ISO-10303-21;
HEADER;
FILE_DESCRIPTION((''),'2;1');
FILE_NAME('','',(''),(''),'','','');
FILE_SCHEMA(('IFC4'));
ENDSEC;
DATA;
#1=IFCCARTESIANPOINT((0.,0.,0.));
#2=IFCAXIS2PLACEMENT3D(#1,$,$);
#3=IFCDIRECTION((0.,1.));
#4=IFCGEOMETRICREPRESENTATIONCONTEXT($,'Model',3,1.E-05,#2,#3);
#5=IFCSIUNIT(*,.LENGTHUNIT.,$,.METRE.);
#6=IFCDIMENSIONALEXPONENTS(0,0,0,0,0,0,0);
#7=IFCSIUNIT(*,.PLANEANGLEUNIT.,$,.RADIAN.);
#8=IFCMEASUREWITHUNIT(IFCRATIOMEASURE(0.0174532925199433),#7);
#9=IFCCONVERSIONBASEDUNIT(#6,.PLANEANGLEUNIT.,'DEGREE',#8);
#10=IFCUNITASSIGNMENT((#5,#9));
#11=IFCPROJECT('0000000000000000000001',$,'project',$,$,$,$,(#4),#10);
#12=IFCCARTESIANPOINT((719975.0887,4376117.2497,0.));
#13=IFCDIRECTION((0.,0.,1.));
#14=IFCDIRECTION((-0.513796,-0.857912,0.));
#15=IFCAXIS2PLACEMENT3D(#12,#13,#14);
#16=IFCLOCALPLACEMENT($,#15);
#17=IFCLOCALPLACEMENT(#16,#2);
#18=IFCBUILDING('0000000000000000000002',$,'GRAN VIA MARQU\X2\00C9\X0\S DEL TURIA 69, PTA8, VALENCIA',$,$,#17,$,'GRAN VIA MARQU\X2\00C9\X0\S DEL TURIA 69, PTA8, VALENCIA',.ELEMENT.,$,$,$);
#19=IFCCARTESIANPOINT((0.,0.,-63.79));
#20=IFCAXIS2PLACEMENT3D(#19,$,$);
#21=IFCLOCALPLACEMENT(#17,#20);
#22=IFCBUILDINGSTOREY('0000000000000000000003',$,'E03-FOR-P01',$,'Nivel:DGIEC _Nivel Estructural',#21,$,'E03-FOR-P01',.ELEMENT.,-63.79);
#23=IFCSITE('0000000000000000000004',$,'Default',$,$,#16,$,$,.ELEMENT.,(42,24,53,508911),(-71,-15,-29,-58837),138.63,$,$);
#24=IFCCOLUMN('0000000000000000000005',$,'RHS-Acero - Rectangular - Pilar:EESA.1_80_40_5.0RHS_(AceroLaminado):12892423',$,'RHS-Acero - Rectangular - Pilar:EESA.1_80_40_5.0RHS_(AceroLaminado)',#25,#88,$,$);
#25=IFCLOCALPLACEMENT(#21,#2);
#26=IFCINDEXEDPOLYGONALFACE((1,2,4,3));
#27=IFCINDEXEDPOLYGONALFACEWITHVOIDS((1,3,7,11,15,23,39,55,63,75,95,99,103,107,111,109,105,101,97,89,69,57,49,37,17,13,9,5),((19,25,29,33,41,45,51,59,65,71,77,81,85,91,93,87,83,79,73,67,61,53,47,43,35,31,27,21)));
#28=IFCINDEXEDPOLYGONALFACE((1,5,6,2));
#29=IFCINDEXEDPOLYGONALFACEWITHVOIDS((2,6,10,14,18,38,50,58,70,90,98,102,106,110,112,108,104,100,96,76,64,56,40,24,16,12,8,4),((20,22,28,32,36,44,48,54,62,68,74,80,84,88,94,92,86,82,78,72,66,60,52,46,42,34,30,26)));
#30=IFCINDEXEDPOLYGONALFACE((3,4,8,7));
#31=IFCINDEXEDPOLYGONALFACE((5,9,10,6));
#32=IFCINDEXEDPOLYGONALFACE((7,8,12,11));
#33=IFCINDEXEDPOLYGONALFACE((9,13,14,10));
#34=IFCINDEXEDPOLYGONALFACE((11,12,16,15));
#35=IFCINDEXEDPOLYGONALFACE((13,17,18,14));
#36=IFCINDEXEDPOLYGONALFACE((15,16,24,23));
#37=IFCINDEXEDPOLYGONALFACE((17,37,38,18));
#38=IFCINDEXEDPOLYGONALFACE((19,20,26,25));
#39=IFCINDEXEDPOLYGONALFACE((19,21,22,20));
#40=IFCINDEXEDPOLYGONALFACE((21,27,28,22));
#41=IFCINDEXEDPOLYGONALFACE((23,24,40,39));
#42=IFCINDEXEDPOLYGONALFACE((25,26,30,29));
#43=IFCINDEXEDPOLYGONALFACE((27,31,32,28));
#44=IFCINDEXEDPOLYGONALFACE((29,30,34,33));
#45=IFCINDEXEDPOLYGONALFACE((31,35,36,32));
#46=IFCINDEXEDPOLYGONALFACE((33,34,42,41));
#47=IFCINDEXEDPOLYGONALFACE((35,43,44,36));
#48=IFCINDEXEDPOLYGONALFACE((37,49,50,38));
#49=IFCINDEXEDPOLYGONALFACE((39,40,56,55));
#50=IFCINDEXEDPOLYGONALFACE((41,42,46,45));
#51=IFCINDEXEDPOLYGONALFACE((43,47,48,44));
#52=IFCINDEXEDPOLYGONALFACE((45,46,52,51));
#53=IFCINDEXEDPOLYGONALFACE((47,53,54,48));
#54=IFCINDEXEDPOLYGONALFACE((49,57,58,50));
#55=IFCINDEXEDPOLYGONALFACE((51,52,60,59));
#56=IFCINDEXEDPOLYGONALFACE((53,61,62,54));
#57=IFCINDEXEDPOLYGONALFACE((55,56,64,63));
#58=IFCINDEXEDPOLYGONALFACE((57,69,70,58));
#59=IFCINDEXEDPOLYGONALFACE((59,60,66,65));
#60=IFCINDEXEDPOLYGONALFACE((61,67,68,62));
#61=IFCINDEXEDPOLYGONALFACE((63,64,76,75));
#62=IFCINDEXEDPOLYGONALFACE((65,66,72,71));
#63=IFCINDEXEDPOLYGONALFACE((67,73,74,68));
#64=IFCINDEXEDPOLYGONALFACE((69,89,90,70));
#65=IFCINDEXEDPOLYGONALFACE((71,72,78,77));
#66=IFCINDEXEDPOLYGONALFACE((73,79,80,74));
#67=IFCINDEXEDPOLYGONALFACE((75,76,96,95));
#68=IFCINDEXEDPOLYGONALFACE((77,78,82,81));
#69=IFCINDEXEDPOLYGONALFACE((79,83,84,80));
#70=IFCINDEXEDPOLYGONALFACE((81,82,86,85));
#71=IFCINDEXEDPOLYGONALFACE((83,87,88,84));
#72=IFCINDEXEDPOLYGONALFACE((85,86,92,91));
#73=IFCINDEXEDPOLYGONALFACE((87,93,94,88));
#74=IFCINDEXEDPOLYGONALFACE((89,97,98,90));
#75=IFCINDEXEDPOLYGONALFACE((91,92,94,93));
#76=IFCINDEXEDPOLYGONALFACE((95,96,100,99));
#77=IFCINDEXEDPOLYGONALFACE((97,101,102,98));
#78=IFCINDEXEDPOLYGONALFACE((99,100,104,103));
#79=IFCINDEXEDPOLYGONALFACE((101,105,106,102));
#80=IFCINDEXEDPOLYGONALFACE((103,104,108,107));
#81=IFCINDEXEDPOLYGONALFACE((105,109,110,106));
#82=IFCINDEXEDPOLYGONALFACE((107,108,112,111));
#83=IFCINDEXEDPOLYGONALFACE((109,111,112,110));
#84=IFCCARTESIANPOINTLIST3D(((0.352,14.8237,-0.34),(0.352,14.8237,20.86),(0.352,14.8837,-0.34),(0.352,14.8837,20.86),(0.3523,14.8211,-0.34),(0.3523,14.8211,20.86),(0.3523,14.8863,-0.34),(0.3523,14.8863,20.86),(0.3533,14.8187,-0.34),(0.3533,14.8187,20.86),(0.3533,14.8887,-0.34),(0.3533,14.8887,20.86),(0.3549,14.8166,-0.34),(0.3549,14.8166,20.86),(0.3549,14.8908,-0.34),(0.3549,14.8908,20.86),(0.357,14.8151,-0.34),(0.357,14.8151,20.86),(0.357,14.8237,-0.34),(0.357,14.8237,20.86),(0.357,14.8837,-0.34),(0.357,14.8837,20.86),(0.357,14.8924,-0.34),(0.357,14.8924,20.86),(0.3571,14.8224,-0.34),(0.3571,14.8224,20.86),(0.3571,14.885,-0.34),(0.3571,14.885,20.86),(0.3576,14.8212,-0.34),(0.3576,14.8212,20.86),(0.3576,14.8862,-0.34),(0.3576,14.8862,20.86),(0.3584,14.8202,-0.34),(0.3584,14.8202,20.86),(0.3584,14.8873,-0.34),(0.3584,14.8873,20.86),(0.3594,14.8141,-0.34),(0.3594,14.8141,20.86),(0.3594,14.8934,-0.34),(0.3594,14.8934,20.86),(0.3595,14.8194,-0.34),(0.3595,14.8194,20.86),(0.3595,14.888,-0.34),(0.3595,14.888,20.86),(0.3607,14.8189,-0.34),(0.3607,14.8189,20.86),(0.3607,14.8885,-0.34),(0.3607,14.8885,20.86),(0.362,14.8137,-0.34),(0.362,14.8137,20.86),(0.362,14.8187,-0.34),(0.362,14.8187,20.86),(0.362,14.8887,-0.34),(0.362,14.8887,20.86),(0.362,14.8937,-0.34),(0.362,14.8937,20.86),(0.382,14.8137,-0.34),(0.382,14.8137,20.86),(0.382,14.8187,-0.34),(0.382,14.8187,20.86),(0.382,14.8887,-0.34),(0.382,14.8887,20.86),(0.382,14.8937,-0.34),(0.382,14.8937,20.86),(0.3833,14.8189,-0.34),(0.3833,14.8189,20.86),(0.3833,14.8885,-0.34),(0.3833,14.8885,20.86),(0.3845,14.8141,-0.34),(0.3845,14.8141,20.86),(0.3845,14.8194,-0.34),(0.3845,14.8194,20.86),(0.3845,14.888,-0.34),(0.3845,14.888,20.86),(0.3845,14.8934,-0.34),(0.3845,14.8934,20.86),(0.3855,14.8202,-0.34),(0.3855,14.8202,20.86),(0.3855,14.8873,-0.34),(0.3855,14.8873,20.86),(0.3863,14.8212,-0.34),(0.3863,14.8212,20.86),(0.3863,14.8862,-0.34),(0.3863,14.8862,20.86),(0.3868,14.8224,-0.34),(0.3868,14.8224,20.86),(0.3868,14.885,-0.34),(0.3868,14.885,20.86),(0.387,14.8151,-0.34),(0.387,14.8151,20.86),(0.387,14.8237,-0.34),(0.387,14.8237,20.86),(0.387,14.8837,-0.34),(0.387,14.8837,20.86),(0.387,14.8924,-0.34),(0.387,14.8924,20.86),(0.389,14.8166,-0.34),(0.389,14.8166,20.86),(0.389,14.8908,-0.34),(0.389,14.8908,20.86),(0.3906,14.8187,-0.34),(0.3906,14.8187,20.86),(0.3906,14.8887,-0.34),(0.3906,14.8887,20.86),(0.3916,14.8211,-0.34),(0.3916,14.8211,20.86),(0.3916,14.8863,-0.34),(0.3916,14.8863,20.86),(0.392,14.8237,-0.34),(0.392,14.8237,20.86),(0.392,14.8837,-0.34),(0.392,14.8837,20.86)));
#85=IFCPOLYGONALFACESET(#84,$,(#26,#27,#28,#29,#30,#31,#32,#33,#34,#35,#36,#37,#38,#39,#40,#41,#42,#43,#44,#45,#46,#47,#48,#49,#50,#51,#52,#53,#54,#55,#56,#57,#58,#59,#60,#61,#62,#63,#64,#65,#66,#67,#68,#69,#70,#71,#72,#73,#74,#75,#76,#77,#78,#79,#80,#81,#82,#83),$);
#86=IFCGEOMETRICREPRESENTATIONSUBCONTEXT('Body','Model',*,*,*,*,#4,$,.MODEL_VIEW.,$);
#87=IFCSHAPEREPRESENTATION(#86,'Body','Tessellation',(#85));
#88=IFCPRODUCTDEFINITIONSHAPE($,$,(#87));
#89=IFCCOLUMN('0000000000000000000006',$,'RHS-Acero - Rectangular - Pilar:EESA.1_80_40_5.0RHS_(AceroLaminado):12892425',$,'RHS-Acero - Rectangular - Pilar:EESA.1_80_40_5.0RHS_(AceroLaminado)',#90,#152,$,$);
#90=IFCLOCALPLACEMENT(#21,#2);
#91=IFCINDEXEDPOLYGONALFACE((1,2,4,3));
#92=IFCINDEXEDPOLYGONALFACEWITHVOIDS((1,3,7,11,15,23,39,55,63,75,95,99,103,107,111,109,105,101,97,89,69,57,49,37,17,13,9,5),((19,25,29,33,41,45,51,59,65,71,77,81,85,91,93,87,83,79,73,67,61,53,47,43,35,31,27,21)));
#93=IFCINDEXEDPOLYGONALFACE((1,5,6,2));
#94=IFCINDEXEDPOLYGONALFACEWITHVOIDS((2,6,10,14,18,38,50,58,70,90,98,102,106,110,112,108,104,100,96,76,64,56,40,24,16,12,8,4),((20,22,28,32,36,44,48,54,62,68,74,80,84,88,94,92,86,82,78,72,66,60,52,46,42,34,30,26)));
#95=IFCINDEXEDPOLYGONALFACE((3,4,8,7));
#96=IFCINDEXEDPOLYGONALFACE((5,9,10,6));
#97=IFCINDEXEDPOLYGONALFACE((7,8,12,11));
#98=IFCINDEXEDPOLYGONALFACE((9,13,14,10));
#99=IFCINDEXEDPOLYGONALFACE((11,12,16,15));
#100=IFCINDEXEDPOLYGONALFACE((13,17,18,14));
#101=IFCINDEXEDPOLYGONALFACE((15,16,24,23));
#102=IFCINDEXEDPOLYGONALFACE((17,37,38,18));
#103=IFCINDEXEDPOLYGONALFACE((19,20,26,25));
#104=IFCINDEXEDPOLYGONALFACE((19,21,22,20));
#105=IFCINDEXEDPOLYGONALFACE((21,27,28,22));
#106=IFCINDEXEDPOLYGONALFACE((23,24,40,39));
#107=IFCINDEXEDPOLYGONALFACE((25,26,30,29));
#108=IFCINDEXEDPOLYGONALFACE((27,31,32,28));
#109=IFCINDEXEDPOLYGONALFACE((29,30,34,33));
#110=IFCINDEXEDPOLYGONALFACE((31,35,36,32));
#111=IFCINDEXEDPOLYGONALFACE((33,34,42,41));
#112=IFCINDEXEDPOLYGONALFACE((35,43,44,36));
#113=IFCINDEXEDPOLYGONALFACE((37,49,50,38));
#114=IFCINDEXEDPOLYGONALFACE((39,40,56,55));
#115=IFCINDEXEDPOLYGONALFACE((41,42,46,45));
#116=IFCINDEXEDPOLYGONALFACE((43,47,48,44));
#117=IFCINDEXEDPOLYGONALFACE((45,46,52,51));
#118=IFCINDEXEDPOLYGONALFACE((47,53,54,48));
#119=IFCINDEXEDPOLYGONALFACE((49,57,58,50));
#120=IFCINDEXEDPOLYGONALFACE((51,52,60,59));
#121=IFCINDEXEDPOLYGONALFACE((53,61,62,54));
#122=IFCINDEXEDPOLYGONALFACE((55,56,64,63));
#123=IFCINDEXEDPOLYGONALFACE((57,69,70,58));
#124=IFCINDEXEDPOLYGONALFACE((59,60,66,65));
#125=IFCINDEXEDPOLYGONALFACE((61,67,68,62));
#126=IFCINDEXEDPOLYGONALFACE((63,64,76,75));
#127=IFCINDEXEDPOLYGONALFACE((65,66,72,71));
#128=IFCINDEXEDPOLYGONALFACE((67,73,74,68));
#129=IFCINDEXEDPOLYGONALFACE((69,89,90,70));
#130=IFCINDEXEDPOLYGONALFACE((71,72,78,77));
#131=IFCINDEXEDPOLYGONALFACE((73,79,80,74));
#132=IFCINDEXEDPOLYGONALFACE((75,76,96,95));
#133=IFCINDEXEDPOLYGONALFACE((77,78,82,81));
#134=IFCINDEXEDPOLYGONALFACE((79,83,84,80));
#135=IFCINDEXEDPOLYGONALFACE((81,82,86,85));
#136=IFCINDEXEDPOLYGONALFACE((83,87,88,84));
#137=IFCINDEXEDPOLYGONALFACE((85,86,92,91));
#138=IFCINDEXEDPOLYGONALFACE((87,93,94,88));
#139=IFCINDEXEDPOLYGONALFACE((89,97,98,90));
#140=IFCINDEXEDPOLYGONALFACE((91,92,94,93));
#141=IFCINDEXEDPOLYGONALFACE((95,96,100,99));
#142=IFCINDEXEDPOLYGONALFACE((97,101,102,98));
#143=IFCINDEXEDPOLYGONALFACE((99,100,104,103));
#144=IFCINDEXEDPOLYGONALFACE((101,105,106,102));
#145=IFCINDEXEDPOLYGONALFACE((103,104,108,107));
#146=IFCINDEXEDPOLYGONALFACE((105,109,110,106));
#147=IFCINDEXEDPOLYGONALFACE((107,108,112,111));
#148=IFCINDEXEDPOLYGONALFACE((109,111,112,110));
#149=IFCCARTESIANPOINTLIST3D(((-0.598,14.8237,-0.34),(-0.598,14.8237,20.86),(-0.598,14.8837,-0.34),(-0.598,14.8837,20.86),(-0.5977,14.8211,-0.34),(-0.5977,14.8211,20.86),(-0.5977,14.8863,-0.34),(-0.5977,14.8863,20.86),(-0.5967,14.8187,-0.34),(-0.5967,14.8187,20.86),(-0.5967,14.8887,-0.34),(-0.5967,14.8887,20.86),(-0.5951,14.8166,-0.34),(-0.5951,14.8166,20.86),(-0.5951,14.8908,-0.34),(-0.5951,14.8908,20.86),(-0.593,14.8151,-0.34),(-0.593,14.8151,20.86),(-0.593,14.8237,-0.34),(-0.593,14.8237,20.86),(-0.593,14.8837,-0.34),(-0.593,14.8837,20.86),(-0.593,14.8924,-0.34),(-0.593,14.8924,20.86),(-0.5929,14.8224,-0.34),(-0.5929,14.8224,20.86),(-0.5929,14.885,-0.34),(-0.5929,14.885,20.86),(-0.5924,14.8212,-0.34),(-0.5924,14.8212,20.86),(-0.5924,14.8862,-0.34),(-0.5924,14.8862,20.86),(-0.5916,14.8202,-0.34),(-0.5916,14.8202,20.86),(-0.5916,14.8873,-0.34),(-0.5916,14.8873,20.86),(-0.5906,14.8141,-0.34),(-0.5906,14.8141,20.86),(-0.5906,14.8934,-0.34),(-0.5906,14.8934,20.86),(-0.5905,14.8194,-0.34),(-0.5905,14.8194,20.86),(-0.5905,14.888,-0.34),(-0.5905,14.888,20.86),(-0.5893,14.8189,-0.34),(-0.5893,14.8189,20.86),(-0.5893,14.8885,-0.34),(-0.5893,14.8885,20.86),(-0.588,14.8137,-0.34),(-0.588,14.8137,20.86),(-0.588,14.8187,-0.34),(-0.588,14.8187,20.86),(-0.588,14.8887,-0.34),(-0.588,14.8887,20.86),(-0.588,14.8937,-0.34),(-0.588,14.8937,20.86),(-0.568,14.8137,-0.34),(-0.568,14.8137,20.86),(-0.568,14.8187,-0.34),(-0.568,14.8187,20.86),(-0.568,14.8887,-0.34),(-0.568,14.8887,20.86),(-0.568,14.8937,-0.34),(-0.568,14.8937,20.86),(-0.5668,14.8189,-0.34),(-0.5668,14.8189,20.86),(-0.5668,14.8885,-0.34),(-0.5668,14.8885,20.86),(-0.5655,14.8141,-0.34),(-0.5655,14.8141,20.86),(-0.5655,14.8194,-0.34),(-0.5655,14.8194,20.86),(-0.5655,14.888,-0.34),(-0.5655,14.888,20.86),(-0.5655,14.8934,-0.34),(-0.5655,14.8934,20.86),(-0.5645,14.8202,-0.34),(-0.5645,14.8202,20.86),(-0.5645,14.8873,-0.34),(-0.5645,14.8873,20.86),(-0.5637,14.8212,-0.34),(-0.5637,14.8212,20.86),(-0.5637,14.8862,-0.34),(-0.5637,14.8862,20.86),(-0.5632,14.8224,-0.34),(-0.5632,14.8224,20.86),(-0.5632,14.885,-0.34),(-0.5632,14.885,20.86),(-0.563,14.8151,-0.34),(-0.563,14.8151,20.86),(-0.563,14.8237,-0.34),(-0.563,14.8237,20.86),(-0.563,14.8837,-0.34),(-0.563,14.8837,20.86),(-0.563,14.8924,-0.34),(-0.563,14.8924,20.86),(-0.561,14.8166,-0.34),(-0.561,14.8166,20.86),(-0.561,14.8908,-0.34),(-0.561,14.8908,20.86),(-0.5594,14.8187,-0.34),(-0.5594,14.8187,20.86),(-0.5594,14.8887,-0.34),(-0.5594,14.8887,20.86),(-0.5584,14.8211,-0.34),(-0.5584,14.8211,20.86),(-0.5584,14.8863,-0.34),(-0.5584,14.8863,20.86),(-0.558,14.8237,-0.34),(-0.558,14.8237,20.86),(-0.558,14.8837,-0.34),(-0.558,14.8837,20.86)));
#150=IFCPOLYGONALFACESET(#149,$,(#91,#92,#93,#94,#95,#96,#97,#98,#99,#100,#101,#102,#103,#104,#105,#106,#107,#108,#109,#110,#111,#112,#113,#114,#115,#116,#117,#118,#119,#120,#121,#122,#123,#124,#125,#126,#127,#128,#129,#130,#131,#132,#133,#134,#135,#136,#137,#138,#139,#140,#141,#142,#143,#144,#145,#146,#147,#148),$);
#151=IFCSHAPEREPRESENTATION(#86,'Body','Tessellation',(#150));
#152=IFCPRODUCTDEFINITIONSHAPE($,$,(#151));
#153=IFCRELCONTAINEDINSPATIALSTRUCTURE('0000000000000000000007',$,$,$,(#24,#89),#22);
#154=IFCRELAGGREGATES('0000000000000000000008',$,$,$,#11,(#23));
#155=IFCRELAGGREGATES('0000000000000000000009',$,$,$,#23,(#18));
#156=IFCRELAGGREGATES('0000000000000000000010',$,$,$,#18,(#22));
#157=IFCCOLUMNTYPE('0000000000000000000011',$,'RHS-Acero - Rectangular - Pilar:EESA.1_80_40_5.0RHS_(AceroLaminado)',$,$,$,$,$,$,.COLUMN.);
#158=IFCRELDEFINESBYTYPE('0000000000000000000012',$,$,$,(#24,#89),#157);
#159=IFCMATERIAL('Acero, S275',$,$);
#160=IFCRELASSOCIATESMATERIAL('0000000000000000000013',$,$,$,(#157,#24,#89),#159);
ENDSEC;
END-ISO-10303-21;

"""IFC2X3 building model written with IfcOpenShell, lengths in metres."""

from ifc_helpers import new_model, entity, si_unit, converted_unit, direction, frame, frame_2d, origin, place, context, subcontext, project, spatial, polyline, circle_curve, parameter, trimmed, segment, composite_curve, outline, extrude, source, transform, mapped, material, type_object, type_shapes, element, save


model = new_model("IFC2X3")

# Units and contexts
model_context = context("Model", 3, precision=1e-05, world=origin(), true_north=direction((0.0, 1.0)))
body_context = subcontext(model_context, "Body", "Model", "MODEL_VIEW")
ifc_project = project(units=[si_unit("LENGTHUNIT", "METRE"), converted_unit("PLANEANGLEUNIT", "DEGREE", entity("IfcRatioMeasure", 0.0174532925199433), si_unit("PLANEANGLEUNIT", "RADIAN"), dimensions=[0, 0, 0, 0, 0, 0, 0])], contexts=[model_context])

# Site, building, storey
site_placement = place(None, frame((719975.0887, 4376117.2497, 0.0), z_axis=(0.0, 0.0, 1.0), x_axis=(-0.513796, -0.857912, 0.0)))
site = spatial("IfcSite", under=ifc_project, at=site_placement, Name="Default", CompositionType="ELEMENT", RefLatitude=(42, 24, 53, 508911), RefLongitude=(-71, -15, -29, -58837), RefElevation=138.63)
building_placement = place(site_placement, origin())
building = spatial("IfcBuilding", under=site, at=building_placement, Name="GRAN VIA MARQUÉS DEL TURIA 69, PTA8, VALENCIA", LongName="GRAN VIA MARQUÉS DEL TURIA 69, PTA8, VALENCIA", CompositionType="ELEMENT")
storey_placement = place(building_placement, frame((0.0, 0.0, -63.79)))
storey = spatial("IfcBuildingStorey", under=building, at=storey_placement, Name="E03-FOR-P01", ObjectType="Nivel:DGIEC _Nivel Estructural", LongName="E03-FOR-P01", CompositionType="ELEMENT", Elevation=-63.79)

# Columns
ifc_material_1 = material(Name="Acero, S275")
column_type_1 = type_object("IfcColumnType", Name="RHS-Acero - Rectangular - Pilar:EESA.1_80_40_5.0RHS_(AceroLaminado)", PredefinedType="COLUMN", material=ifc_material_1)
shared_shape_1 = source(origin(), body_context, "Body", "SweptSolid", [
    extrude(outline(composite_curve([segment(polyline([(-0.01, -0.04), (0.01, -0.04)]), True, "CONTINUOUS"), segment(trimmed(circle_curve(frame_2d((0.01, -0.03), x_axis=(-1.0, 0.0)), 0.01), [parameter(90.0)], [parameter(180.0)], True, "PARAMETER"), True, "CONTINUOUS"), segment(polyline([(0.02, -0.03), (0.02, 0.03)]), True, "CONTINUOUS"), segment(trimmed(circle_curve(frame_2d((0.01, 0.03), x_axis=(-1.0, 0.0)), 0.01), [parameter(180.0)], [parameter(270.0)], True, "PARAMETER"), True, "CONTINUOUS"), segment(polyline([(0.01, 0.04), (-0.01, 0.04)]), True, "CONTINUOUS"), segment(trimmed(circle_curve(frame_2d((-0.01, 0.03), x_axis=(-1.0, 0.0)), 0.01), [parameter(270.0)], [parameter(360.0)], True, "PARAMETER"), True, "CONTINUOUS"), segment(polyline([(-0.02, 0.03), (-0.02, -0.03)]), True, "CONTINUOUS"), segment(trimmed(circle_curve(frame_2d((-0.01, -0.03), x_axis=(-1.0, 0.0)), 0.01), [parameter(360.0)], [parameter(90.0)], True, "PARAMETER"), True, "CONTINUOUS")], self_intersect=False), holes=[composite_curve([segment(trimmed(circle_curve(frame_2d((-0.01, -0.03), x_axis=(-1.0, 0.0)), 0.005), [parameter(0.0)], [parameter(90.0)], True, "PARAMETER"), False, "CONTINUOUS"), segment(polyline([(-0.015, -0.03), (-0.015, 0.03)]), True, "CONTINUOUS"), segment(trimmed(circle_curve(frame_2d((-0.01, 0.03), x_axis=(-1.0, 0.0)), 0.005), [parameter(270.0)], [parameter(0.0)], True, "PARAMETER"), False, "CONTINUOUS"), segment(polyline([(-0.01, 0.035), (0.01, 0.035)]), True, "CONTINUOUS"), segment(trimmed(circle_curve(frame_2d((0.01, 0.03), x_axis=(-1.0, 0.0)), 0.005), [parameter(180.0)], [parameter(270.0)], True, "PARAMETER"), False, "CONTINUOUS"), segment(polyline([(0.015, 0.03), (0.015, -0.03)]), True, "CONTINUOUS"), segment(trimmed(circle_curve(frame_2d((0.01, -0.03), x_axis=(-1.0, 0.0)), 0.005), [parameter(90.0)], [parameter(180.0)], True, "PARAMETER"), False, "CONTINUOUS"), segment(polyline([(0.01, -0.035), (-0.01, -0.035)]), True, "CONTINUOUS")], self_intersect=False)]), frame((0.0, 0.0, -64.13), z_axis=(0.0, 0.0, 1.0), x_axis=(-1.0, 0.0, 0.0)), (0.0, 0.0, 1.0), 21.2),
])
type_shapes(column_type_1, [shared_shape_1])
for number, where, z_axis, x_axis, name in (
    (1, (0.372, 14.8537, 63.79), (0.0, 0.0, 1.0), (-1.0, 0.0, 0.0), "RHS-Acero - Rectangular - Pilar:EESA.1_80_40_5.0RHS_(AceroLaminado):12892423"),
    (2, (-0.578, 14.8537, 63.79), (0.0, 0.0, 1.0), (-1.0, 0.0, 0.0), "RHS-Acero - Rectangular - Pilar:EESA.1_80_40_5.0RHS_(AceroLaminado):12892425"),
):
    element("IfcColumn", number, at=place(storey_placement, frame(where, z_axis=z_axis, x_axis=x_axis)), inside=storey, type_object=column_type_1, material=ifc_material_1, Name=name, ObjectType="RHS-Acero - Rectangular - Pilar:EESA.1_80_40_5.0RHS_(AceroLaminado)", context=body_context, shape_type="MappedRepresentation", body=[
        mapped(shared_shape_1, transform((0.0, 0.0, 0.0), scale=1.0)),
    ])

save(model, "model.ifc")
